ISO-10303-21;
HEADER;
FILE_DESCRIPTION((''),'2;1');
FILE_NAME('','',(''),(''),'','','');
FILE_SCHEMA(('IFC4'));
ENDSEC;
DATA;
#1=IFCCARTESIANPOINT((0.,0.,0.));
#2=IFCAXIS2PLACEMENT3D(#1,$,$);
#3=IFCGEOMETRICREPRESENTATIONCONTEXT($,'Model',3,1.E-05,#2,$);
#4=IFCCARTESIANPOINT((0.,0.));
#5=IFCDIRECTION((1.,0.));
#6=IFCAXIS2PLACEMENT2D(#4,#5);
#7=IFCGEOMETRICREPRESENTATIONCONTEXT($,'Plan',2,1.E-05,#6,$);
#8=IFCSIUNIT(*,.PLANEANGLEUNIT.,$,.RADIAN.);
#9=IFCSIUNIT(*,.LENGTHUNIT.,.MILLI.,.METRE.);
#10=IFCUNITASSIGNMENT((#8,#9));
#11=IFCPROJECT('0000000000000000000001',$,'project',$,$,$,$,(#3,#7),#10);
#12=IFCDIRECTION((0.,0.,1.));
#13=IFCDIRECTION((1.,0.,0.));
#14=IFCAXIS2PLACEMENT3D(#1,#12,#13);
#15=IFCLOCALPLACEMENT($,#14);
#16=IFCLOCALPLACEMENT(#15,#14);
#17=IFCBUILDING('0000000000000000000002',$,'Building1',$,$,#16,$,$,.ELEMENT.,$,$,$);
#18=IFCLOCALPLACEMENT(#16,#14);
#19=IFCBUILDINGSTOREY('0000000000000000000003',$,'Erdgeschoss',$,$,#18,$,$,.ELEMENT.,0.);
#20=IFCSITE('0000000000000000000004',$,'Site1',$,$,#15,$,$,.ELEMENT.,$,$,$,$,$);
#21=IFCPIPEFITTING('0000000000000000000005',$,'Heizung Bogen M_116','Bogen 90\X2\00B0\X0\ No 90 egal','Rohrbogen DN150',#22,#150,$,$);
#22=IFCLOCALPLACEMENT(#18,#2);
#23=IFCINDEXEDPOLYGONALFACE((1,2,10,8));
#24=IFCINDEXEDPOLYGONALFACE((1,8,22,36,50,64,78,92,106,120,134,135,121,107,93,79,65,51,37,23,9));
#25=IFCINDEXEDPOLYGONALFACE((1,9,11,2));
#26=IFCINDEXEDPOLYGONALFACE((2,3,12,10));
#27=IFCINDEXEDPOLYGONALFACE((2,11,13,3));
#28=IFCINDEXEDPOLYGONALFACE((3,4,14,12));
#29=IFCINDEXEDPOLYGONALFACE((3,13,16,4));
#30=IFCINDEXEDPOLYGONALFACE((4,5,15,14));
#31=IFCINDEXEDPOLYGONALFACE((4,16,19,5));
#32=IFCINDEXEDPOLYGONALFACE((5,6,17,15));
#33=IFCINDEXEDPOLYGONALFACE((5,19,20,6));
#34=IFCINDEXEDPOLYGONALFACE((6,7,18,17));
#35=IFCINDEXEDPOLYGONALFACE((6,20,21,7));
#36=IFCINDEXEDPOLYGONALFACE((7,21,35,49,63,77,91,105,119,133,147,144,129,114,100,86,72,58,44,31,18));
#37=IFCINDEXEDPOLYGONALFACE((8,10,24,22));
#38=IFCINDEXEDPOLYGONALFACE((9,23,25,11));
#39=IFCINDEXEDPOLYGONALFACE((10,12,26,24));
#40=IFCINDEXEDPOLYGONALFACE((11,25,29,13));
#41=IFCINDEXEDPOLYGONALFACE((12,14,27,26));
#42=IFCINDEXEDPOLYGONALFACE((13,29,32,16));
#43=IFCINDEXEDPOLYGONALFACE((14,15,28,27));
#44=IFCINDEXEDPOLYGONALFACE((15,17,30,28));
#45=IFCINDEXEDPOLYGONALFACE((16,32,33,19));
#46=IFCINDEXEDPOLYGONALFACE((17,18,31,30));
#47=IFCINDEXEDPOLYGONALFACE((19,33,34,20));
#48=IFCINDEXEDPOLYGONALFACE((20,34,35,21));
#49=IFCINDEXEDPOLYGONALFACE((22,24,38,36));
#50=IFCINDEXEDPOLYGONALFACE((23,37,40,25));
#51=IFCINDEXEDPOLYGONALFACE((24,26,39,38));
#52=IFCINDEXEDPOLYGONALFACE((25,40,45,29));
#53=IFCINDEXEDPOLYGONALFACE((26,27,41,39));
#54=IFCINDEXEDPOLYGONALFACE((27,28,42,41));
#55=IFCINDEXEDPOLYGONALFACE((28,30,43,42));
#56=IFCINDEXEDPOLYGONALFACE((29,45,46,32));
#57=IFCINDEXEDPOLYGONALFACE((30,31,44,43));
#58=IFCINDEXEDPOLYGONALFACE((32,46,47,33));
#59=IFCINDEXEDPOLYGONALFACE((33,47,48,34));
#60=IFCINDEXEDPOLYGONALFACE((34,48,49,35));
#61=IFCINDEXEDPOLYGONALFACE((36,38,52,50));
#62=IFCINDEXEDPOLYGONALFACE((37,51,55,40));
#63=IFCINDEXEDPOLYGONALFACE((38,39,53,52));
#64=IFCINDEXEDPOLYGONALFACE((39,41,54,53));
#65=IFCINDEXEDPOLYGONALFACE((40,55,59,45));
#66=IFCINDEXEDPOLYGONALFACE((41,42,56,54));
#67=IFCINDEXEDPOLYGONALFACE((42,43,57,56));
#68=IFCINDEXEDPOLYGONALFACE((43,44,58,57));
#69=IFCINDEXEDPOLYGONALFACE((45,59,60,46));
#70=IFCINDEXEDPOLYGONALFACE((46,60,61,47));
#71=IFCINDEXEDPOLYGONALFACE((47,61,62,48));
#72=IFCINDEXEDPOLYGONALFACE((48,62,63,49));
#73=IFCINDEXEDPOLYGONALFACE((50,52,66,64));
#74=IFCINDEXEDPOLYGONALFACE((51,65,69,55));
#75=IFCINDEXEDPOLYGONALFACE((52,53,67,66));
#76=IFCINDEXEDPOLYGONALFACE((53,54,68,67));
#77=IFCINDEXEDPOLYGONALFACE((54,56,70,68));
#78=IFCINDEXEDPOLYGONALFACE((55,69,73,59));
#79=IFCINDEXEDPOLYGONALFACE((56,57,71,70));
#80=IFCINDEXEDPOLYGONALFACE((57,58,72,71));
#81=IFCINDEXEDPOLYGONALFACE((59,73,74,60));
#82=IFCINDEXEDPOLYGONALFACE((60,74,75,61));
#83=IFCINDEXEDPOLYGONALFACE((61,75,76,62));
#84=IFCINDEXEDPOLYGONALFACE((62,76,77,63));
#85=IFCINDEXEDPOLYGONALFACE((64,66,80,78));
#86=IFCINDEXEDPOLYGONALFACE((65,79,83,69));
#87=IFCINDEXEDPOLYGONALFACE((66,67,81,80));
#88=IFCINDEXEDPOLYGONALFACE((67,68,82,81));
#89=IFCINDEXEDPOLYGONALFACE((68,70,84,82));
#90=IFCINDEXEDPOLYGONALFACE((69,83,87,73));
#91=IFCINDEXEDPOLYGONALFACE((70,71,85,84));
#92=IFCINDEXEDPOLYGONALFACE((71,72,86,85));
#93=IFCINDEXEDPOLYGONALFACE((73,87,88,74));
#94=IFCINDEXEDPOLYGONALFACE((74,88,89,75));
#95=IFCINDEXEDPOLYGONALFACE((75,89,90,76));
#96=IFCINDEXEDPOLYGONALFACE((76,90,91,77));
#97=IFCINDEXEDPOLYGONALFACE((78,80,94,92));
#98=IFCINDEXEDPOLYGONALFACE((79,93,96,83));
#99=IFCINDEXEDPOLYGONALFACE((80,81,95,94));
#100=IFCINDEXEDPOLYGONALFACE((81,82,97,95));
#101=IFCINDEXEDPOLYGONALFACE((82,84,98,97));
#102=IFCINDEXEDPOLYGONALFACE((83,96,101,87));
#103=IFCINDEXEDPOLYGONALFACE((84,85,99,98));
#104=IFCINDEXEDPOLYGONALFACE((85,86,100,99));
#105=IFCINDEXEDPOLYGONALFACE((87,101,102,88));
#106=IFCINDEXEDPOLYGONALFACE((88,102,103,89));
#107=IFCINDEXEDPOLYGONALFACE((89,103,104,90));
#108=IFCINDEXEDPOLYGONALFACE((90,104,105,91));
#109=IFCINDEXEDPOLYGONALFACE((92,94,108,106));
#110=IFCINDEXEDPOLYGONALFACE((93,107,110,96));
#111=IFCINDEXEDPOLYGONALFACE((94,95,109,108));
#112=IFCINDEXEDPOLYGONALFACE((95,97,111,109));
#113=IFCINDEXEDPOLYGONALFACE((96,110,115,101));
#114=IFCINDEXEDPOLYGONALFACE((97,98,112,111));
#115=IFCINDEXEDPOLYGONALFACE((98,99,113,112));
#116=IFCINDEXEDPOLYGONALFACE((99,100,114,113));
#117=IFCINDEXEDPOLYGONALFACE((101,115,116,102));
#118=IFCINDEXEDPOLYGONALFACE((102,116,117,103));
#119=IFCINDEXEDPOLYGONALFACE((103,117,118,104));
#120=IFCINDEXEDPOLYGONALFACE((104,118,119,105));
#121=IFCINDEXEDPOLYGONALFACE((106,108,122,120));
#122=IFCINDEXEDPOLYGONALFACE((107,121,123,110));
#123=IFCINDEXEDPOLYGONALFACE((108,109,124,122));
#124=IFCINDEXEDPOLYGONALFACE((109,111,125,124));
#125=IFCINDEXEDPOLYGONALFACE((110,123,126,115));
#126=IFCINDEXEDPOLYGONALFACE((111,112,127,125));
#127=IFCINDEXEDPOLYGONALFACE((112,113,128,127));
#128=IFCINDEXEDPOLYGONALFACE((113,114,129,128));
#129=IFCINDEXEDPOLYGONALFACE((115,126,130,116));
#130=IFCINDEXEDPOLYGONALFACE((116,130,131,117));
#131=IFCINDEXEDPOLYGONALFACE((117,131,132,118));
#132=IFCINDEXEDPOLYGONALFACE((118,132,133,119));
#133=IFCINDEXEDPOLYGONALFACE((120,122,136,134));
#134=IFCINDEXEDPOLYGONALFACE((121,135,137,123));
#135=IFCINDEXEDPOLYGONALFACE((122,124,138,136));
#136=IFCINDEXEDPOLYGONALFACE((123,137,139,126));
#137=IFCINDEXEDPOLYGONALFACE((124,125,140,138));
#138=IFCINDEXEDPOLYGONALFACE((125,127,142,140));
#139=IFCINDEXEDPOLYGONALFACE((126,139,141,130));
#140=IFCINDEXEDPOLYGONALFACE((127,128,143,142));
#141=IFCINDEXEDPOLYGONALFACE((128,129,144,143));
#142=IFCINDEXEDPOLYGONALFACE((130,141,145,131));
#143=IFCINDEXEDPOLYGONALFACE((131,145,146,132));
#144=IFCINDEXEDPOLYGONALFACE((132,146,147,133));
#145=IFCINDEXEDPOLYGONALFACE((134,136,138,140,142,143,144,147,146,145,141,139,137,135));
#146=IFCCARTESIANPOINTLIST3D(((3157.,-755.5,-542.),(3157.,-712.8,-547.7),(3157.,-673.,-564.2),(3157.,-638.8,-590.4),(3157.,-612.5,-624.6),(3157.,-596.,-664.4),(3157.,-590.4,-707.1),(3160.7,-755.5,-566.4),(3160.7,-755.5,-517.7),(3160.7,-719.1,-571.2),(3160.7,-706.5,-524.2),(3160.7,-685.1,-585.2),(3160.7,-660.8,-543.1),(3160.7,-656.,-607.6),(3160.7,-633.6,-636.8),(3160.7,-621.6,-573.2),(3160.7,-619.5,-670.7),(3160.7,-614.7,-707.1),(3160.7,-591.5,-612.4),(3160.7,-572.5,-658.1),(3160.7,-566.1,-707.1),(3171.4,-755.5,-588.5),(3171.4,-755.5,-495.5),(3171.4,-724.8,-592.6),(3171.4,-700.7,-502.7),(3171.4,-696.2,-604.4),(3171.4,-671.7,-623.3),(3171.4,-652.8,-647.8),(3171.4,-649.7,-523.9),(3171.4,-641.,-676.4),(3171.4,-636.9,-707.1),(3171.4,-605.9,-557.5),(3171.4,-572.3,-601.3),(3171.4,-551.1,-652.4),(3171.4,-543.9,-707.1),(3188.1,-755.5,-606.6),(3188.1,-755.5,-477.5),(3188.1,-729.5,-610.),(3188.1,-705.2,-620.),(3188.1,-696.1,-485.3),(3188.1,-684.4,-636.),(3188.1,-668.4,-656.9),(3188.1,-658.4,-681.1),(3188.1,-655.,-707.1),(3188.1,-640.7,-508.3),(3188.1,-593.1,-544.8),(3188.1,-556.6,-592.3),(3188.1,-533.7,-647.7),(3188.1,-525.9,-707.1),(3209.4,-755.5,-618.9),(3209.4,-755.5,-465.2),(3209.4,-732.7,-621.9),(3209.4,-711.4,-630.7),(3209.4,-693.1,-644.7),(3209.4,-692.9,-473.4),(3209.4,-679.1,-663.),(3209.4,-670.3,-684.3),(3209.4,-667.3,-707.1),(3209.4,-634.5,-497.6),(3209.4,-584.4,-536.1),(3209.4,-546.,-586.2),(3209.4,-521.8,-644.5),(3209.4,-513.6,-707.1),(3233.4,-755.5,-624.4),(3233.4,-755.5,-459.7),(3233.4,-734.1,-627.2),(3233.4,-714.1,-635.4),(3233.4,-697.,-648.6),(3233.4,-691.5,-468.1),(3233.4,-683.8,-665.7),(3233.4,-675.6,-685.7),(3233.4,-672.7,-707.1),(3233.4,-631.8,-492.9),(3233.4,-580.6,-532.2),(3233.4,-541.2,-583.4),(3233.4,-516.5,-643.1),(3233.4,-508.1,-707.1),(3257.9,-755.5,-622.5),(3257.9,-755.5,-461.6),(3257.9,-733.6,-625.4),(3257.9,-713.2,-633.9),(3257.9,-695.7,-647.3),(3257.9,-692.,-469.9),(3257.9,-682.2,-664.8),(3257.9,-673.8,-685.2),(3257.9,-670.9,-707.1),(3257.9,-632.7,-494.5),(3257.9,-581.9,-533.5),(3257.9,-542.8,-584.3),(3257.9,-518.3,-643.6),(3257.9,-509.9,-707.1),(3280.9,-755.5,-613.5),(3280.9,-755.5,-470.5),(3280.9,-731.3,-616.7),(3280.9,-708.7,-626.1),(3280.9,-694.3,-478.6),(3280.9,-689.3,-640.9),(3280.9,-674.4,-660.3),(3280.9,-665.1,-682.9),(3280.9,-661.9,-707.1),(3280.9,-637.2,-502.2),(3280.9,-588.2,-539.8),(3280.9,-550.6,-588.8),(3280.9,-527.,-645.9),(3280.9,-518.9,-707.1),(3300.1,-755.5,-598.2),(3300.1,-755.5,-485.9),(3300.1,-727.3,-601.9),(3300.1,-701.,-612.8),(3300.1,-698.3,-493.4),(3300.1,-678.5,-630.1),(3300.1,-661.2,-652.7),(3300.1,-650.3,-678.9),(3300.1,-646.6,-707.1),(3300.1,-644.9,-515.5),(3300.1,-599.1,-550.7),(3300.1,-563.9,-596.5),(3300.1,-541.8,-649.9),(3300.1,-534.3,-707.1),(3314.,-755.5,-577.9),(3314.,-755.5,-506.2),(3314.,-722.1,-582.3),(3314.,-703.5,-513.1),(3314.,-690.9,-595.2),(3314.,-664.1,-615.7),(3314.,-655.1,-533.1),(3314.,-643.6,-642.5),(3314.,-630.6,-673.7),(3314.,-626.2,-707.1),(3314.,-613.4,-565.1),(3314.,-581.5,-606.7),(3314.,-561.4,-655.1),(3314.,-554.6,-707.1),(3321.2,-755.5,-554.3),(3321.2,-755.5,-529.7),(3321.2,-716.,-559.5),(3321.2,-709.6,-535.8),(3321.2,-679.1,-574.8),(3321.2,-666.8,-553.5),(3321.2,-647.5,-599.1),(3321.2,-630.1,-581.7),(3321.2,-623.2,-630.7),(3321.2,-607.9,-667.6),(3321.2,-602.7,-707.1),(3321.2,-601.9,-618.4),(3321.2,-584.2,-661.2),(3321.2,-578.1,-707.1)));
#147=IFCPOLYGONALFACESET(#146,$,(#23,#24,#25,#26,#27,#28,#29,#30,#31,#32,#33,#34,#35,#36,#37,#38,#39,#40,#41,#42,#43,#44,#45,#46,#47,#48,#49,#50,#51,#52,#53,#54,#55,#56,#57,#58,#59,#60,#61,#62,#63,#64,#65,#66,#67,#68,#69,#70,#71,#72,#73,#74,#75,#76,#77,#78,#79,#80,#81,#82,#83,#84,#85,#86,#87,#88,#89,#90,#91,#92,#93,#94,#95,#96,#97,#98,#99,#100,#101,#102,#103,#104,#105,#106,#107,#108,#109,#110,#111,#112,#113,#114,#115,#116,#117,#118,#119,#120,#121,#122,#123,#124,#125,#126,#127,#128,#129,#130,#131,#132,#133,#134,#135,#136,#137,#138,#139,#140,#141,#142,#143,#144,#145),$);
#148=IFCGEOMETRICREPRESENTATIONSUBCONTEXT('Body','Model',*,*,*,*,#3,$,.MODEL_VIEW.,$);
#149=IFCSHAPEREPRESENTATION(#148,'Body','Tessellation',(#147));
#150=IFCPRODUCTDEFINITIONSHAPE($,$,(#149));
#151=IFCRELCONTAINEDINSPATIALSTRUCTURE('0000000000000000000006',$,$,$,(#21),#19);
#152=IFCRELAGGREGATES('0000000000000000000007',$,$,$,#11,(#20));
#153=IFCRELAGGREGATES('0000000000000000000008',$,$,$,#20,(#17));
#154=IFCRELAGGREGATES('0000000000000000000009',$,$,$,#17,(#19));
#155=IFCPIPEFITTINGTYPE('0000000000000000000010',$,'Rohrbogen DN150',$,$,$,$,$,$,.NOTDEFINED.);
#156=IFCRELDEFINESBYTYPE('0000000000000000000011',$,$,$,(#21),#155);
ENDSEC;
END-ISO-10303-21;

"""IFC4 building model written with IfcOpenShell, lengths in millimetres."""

from ifc_helpers import new_model, entity, si_unit, frame, origin, origin_with_axes, origin_2d_with_axis, place, context, subcontext, project, spatial, source, transform, mapped, type_object, element, save


model = new_model("IFC4")

# Units and contexts
model_context = context("Model", 3, precision=1e-05, world=origin())
plan_context = context("Plan", 2, precision=1e-05, world=origin_2d_with_axis())
body_context = subcontext(model_context, "Body", "Model", "MODEL_VIEW")
ifc_project = project(units=[si_unit("PLANEANGLEUNIT", "RADIAN"), si_unit("LENGTHUNIT", "METRE", prefix="MILLI")], contexts=[model_context, plan_context])

# Site, building, storey
site_placement = place(None, origin_with_axes())
site = spatial("IfcSite", under=ifc_project, at=site_placement, Name="Site1", CompositionType="ELEMENT")
building_placement = place(site_placement, origin_with_axes())
building = spatial("IfcBuilding", under=site, at=building_placement, Name="Building1", CompositionType="ELEMENT")
storey_placement = place(building_placement, origin_with_axes())
storey = spatial("IfcBuildingStorey", under=building, at=storey_placement, Name="Erdgeschoss", CompositionType="ELEMENT", Elevation=0.0)

# Pipe fitting
pipe_fitting_type_1 = type_object("IfcPipeFittingType", Name="Rohrbogen DN150", PredefinedType="NOTDEFINED")
ifc_direction_1 = entity("IfcDirection", [-1.0, 0.0, 0.0])
shared_shape_1 = source(origin_with_axes(), body_context, "Body", "SolidModel", [
    entity("IfcRevolvedAreaSolid", entity("IfcCircleProfileDef", "AREA", None, entity("IfcAxis2Placement2D", entity("IfcCartesianPoint", [0.0, 0.0]), entity("IfcDirection", [1.0, 0.0])), 82.5), entity("IfcAxis2Placement3D", entity("IfcCartesianPoint", [123.8, 41.3, 0.0]), ifc_direction_1, entity("IfcDirection", [0.0, 0.0, -1.0])), entity("IfcAxis1Placement", entity("IfcCartesianPoint", [0.0, 165.1, 0.0]), ifc_direction_1), 1.570796),
])
pipe_fitting_1_placement = place(storey_placement, frame((3239.6, -631.7, -583.3), z_axis=(0.0, 0.0, 1.0), x_axis=(1.0, 0.0, 0.0)))
element("IfcPipeFitting", 1, at=pipe_fitting_1_placement, inside=storey, type_object=pipe_fitting_type_1, Name="Heizung Bogen M_116", Description="Bogen 90° No 90 egal", ObjectType="Rohrbogen DN150", context=body_context, shape_type="MappedRepresentation", body=[
    mapped(shared_shape_1, transform((0.0, 0.0, 0.0), x_axis=(0.0, 0.0, -1.0), y_axis=(0.0, 1.0, 0.0), z_axis=(1.0, 0.0, 0.0), scale=1.0)),
])

save(model, "model.ifc")
